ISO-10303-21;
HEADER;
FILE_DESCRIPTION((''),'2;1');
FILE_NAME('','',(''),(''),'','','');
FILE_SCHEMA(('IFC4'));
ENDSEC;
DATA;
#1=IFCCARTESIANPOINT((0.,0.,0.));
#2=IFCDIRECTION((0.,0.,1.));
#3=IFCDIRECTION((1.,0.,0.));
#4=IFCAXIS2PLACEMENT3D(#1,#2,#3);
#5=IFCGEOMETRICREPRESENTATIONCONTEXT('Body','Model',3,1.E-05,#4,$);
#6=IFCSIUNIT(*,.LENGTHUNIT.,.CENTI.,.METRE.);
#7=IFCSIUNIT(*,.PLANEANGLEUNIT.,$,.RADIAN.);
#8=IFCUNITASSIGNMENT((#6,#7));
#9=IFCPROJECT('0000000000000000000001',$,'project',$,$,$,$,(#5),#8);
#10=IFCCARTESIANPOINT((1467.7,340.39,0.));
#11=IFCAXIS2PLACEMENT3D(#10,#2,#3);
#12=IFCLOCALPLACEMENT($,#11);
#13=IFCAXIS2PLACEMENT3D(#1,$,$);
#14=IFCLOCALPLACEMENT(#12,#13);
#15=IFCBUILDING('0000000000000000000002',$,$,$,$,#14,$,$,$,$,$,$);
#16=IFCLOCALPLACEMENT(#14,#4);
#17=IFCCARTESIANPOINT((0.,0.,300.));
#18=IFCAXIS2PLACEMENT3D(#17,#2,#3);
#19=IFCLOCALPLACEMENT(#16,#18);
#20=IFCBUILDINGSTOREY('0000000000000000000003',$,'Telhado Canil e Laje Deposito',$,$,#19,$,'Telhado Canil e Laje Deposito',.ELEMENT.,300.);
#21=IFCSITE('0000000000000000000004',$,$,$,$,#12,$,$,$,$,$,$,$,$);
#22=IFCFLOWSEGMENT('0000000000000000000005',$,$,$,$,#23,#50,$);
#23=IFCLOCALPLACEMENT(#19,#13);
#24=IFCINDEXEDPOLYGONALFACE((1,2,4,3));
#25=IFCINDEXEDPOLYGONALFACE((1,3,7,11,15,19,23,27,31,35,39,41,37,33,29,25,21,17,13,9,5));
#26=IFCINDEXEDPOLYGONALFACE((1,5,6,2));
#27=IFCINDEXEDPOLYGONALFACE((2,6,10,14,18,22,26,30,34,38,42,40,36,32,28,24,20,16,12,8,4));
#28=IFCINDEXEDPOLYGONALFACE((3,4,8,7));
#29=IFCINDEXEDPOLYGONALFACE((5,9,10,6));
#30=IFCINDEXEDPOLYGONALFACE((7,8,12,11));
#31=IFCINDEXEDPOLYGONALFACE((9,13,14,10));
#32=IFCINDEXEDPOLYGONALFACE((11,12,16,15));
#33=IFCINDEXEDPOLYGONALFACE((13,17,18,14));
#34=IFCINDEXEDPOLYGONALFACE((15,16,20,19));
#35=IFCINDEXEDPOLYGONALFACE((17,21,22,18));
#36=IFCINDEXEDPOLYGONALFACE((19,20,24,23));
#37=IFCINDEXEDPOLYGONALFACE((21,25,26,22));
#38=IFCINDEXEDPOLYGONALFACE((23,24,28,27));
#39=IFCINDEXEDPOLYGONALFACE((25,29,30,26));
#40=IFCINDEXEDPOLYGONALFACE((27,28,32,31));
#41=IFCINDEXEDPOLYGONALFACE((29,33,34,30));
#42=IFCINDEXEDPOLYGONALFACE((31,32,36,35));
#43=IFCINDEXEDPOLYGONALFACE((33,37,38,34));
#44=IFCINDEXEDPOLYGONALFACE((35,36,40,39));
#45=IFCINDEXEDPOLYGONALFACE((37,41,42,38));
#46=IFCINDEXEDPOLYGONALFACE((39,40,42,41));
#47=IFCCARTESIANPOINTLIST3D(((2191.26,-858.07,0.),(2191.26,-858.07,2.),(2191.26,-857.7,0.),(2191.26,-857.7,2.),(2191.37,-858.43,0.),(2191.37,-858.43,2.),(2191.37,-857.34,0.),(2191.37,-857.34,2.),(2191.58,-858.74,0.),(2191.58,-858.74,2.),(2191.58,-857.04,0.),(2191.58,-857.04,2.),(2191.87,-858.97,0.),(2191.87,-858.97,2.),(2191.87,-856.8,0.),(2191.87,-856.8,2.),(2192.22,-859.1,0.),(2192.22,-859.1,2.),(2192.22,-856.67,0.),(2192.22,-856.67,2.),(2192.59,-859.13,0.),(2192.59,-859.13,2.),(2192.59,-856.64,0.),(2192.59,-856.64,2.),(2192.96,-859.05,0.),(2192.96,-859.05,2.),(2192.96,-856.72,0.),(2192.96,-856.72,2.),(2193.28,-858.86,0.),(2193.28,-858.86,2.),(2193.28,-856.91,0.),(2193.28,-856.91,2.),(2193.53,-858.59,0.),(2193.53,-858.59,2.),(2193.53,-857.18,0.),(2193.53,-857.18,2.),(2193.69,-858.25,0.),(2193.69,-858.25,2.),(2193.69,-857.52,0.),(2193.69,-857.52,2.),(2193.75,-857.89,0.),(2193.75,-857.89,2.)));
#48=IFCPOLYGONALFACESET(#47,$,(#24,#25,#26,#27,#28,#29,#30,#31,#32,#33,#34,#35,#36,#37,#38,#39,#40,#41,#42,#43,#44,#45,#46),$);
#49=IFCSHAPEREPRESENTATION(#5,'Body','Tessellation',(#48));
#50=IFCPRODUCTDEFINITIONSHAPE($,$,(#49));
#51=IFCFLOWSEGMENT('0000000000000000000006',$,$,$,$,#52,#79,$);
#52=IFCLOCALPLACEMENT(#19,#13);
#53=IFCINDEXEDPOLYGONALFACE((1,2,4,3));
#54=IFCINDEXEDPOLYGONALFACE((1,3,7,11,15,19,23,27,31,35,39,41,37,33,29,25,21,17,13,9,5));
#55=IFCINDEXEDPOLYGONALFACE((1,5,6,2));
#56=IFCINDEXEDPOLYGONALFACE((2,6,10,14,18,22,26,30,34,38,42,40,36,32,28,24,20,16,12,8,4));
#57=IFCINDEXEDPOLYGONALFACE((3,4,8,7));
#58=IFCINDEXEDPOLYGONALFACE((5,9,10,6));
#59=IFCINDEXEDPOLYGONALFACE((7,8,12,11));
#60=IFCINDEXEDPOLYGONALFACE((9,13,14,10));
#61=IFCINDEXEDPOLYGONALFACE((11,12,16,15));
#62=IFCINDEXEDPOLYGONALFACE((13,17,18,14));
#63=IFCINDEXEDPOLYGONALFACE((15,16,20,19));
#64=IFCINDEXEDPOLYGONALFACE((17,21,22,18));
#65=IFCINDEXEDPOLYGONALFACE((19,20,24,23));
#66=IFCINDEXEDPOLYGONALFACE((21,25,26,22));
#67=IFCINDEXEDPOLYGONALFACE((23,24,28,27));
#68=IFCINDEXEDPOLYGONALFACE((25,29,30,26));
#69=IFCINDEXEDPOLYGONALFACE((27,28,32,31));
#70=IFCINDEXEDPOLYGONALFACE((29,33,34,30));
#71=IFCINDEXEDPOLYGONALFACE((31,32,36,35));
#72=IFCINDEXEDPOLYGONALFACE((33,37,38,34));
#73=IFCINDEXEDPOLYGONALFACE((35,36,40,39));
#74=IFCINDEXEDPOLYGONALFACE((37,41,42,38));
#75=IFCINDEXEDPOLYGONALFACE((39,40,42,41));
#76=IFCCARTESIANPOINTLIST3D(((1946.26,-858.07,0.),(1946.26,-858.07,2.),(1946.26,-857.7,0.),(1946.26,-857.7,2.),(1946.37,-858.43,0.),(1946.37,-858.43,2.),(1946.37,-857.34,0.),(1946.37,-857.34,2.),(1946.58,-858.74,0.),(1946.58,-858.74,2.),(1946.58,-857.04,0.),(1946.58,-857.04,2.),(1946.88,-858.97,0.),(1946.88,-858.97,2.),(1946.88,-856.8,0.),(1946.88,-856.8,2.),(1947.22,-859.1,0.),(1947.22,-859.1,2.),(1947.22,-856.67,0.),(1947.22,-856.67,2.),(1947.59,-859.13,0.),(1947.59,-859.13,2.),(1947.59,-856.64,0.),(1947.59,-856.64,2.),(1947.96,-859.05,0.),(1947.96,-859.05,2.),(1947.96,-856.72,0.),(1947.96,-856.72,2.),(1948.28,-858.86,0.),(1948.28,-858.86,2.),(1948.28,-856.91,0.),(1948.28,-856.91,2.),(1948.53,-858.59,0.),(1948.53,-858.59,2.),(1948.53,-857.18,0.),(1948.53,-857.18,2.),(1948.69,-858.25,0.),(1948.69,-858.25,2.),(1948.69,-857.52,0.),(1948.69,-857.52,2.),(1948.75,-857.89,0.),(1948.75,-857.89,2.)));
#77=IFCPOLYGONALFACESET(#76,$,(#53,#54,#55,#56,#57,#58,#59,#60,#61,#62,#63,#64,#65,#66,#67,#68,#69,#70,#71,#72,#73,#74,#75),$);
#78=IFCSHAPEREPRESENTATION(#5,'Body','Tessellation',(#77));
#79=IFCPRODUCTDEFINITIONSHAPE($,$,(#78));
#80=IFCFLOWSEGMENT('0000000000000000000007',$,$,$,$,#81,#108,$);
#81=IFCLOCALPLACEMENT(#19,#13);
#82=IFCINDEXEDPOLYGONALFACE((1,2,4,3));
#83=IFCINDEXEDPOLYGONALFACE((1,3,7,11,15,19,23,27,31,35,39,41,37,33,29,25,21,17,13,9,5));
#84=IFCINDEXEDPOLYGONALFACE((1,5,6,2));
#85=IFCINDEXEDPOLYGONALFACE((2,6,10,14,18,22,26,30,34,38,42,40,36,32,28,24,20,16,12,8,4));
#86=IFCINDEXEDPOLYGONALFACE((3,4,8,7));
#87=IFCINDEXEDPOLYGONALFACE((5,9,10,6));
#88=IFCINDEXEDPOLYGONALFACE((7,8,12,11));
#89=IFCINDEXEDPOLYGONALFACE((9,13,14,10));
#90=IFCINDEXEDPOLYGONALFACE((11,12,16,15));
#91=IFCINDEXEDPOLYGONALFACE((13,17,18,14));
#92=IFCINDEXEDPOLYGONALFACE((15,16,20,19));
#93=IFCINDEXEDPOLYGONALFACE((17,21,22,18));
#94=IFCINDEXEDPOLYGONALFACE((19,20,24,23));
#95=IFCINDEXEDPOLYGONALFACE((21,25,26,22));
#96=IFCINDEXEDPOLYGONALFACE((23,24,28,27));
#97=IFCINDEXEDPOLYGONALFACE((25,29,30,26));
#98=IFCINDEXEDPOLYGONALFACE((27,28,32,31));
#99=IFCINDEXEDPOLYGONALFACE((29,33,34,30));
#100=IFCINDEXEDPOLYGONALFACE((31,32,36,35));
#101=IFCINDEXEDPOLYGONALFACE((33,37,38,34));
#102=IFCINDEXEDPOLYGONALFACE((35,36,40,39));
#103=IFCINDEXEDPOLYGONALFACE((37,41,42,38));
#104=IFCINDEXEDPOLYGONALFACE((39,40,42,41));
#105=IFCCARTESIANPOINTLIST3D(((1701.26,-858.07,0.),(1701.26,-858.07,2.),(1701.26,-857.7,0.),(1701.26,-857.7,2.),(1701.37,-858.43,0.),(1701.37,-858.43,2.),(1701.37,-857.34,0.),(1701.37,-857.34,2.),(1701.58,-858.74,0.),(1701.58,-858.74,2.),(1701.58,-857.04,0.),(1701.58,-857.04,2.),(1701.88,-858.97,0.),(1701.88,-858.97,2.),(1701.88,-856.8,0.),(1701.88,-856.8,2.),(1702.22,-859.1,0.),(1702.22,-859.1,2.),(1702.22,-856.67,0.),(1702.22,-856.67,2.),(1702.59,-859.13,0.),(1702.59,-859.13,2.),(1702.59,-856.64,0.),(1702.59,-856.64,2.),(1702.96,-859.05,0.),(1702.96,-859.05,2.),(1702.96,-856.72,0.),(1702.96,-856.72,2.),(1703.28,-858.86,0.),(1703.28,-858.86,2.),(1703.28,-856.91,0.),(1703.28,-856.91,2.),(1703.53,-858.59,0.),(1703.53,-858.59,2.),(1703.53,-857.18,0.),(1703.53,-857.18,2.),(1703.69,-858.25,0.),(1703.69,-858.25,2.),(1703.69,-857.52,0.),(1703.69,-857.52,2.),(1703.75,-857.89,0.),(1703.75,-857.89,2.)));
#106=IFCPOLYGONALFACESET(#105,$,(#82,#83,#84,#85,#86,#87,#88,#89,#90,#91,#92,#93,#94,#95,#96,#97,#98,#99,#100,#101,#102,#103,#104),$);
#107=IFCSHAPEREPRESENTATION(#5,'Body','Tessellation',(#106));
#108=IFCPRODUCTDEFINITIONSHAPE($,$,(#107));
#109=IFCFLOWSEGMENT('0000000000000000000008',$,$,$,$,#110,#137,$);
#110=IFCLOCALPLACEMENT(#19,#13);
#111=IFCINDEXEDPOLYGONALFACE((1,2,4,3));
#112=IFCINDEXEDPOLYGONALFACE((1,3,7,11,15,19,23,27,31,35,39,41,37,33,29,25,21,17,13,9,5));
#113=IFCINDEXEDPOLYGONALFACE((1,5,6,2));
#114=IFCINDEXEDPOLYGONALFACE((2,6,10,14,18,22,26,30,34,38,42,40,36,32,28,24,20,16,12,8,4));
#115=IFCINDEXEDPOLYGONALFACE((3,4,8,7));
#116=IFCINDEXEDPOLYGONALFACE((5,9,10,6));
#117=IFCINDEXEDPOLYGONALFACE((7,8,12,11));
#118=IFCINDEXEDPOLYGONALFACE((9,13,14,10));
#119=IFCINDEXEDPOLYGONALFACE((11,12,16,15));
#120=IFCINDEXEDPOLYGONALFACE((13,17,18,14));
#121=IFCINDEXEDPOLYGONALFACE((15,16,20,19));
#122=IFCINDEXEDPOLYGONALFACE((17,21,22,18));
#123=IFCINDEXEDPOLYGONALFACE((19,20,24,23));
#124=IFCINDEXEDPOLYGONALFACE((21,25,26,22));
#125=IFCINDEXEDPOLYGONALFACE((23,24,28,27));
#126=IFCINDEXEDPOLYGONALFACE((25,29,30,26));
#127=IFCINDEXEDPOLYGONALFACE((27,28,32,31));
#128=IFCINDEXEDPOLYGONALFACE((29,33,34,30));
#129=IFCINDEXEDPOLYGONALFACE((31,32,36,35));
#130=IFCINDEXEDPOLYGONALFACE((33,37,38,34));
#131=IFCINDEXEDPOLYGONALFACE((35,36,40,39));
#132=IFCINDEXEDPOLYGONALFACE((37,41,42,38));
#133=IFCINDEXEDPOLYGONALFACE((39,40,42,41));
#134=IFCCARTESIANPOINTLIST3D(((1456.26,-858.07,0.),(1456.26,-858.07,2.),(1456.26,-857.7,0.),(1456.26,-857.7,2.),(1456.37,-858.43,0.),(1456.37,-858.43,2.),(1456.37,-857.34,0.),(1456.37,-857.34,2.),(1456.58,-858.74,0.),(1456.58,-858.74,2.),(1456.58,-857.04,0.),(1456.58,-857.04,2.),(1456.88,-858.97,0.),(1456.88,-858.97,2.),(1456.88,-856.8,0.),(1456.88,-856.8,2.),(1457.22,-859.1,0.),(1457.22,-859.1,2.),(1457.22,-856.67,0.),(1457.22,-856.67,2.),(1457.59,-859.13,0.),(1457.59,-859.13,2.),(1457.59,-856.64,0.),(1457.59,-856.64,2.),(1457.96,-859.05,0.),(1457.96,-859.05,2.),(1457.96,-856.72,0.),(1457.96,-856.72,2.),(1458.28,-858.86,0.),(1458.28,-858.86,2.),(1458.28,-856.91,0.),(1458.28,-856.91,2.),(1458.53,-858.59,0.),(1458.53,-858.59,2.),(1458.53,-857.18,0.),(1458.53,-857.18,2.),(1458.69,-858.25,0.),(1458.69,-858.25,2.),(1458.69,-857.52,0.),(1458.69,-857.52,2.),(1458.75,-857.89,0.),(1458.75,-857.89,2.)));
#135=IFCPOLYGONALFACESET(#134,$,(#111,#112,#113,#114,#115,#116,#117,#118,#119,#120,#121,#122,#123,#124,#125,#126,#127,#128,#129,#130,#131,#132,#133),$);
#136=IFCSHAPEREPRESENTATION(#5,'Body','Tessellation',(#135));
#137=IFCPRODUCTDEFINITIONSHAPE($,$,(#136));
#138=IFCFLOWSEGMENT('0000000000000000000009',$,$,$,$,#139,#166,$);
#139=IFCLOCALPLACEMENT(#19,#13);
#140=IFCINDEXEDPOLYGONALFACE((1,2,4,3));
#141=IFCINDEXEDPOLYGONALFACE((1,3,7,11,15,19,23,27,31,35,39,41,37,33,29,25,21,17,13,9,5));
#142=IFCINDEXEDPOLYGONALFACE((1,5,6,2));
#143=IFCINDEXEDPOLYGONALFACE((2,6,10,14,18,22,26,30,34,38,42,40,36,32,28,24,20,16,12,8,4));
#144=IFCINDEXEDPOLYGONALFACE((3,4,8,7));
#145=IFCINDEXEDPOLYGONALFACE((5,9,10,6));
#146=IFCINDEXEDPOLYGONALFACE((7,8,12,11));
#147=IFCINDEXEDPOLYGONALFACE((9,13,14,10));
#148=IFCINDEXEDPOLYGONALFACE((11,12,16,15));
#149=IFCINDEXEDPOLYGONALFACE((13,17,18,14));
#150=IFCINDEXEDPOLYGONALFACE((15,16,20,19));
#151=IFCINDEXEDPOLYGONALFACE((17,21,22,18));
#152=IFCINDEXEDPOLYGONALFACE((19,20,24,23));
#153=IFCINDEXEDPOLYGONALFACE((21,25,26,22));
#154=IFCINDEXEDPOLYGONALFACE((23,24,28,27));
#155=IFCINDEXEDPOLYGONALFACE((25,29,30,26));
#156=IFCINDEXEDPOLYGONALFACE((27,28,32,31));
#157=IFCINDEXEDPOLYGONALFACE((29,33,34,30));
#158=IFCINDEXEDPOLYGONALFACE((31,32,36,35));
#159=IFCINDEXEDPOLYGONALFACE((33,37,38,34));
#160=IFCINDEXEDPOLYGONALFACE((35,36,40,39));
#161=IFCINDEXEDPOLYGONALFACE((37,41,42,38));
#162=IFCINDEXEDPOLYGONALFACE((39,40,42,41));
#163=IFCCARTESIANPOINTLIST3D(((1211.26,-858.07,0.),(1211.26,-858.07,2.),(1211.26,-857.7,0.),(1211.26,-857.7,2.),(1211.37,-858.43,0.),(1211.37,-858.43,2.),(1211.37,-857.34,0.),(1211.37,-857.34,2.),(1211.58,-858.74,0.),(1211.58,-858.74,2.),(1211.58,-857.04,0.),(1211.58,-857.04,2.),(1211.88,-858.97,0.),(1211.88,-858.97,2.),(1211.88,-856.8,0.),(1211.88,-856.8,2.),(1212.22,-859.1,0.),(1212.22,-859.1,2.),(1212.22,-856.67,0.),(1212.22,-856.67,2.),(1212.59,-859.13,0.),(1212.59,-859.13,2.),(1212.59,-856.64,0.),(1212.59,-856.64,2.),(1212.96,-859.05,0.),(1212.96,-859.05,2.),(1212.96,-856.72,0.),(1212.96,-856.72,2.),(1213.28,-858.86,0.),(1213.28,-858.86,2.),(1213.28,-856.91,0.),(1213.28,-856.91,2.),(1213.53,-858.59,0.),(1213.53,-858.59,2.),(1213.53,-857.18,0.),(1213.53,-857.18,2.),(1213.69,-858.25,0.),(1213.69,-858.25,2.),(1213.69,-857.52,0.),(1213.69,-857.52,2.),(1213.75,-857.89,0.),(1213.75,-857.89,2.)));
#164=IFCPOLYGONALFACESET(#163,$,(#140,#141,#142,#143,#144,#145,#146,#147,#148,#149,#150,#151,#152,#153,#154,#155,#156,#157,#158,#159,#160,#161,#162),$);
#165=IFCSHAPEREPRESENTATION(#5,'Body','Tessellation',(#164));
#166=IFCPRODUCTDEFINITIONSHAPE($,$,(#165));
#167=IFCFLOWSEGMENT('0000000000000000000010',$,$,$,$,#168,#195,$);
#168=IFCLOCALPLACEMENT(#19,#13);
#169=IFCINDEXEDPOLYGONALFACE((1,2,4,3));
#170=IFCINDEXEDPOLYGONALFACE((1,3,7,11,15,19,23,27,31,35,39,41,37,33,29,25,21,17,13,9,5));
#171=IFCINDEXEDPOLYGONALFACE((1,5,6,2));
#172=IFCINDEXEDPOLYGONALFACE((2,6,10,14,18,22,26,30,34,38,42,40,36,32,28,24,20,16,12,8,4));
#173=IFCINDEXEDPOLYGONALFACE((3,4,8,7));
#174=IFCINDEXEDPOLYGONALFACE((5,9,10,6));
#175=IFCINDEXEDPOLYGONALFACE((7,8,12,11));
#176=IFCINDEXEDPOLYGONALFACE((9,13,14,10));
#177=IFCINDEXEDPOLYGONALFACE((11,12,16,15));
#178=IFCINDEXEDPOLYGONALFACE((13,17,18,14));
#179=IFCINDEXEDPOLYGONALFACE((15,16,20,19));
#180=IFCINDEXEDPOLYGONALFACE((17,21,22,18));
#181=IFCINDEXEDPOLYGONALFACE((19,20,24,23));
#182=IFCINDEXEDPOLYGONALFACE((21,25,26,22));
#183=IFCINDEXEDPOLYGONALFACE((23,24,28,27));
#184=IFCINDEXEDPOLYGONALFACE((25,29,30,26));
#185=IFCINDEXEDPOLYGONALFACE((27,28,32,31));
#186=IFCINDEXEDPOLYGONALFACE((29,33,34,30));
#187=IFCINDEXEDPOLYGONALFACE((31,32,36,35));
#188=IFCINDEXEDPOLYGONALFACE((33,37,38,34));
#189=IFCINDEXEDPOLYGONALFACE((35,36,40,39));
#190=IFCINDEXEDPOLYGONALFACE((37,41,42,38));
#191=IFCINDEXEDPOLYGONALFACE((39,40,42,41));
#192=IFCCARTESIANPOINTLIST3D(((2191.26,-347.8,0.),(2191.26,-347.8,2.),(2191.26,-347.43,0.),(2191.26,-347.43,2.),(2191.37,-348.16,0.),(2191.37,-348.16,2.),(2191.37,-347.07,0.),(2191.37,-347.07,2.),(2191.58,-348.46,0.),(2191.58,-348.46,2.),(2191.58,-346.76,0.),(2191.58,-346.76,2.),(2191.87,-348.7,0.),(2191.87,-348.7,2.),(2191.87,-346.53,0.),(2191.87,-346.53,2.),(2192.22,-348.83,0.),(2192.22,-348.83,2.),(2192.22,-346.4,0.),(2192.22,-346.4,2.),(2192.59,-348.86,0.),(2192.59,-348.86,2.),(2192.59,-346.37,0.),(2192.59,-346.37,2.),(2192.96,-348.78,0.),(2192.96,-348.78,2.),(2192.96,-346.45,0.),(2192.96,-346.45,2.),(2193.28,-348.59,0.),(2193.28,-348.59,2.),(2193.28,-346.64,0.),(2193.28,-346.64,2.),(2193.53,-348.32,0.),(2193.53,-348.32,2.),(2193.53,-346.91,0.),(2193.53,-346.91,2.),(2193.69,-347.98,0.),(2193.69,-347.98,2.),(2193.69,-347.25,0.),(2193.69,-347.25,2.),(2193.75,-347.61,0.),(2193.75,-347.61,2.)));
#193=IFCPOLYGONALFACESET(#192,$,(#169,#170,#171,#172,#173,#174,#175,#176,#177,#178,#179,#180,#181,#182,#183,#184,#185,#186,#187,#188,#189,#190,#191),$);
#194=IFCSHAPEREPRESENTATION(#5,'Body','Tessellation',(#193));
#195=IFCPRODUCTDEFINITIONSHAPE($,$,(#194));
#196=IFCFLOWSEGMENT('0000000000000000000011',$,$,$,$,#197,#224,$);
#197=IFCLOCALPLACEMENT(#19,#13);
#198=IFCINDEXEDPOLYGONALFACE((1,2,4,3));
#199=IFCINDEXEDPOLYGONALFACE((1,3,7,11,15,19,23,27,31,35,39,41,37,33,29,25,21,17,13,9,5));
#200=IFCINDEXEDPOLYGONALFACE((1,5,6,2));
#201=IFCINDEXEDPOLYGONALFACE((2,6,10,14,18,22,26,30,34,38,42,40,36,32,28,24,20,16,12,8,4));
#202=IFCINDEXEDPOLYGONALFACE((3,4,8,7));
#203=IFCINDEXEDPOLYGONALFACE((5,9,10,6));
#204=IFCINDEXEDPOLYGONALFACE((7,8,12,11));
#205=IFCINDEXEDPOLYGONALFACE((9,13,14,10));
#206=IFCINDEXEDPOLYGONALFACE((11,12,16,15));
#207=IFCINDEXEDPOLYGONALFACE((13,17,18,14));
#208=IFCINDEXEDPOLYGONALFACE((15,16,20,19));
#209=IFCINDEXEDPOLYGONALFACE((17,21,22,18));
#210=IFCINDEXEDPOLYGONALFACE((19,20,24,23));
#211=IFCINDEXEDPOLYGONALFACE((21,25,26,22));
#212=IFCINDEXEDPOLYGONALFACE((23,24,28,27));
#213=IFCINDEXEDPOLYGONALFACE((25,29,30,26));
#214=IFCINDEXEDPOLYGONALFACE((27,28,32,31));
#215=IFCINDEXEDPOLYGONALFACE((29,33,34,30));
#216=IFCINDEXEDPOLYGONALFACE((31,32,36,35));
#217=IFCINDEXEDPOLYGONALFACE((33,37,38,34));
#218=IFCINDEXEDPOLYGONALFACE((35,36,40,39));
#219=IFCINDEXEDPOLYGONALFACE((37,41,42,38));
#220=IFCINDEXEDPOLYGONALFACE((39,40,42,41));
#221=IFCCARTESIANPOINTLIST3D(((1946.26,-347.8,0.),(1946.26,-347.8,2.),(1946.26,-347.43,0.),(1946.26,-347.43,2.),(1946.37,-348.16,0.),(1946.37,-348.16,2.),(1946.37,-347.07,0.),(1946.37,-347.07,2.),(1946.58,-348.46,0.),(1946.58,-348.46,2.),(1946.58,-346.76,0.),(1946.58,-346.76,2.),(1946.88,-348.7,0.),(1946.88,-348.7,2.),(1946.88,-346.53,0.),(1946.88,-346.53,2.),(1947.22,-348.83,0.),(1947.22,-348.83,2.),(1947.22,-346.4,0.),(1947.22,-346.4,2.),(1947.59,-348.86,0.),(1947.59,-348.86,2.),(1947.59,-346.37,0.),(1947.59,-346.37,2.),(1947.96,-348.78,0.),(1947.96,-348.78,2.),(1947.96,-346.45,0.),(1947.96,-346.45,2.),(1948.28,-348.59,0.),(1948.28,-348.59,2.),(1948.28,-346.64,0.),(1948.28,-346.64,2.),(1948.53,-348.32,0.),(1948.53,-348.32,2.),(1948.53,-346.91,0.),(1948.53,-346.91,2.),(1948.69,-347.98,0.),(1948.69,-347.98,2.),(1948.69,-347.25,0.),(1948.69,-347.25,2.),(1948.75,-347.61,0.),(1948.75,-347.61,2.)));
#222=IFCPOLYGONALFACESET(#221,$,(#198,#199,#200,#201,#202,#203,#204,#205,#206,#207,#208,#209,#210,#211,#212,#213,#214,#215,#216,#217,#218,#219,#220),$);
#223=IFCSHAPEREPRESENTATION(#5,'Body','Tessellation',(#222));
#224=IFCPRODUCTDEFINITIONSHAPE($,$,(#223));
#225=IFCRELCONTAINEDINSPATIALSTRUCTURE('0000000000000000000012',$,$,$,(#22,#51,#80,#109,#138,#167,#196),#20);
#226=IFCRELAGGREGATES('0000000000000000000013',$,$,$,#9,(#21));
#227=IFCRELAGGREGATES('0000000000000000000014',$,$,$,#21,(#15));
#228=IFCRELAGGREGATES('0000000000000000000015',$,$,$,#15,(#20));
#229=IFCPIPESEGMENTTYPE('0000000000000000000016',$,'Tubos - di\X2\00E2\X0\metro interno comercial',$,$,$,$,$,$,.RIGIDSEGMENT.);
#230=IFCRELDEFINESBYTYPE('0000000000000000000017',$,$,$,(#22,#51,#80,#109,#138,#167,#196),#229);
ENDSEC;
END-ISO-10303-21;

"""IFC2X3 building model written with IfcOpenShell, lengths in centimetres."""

from ifc_helpers import new_model, si_unit, frame, origin, origin_with_axes, origin_2d_with_axis, place, context, project, spatial, circle, extrude, type_object, element, save


model = new_model("IFC2X3")

# Units and contexts
model_context = context("Model", 3, precision=1e-05, world=origin_with_axes(), identifier="Body")
ifc_project = project(units=[si_unit("LENGTHUNIT", "METRE", prefix="CENTI"), si_unit("PLANEANGLEUNIT", "RADIAN")], contexts=[model_context])

# Site, building, storey
site_placement = place(None, frame((1467.7, 340.39, 0.0), z_axis=(0.0, 0.0, 1.0), x_axis=(1.0, 0.0, 0.0)))
site = spatial("IfcSite", under=ifc_project, at=site_placement)
building_placement = place(site_placement, origin())
building = spatial("IfcBuilding", under=site, at=building_placement)
placement = place(building_placement, origin_with_axes())
storey_placement = place(placement, frame((0.0, 0.0, 300.0), z_axis=(0.0, 0.0, 1.0), x_axis=(1.0, 0.0, 0.0)))
storey = spatial("IfcBuildingStorey", under=building, at=storey_placement, Name="Telhado Canil e Laje Deposito", LongName="Telhado Canil e Laje Deposito", CompositionType="ELEMENT", Elevation=300.0)

# Flow segments
pipe_segment_type = type_object("IfcPipeSegmentType", Name="Tubos - diâmetro interno comercial", PredefinedType="RIGIDSEGMENT")
for number, where, z_axis, x_axis in (
    (1, (2192.5, -857.89, 2.0), (0.0, 0.0, 1.0), (1.0, 0.0, 0.0)),
    (2, (1947.5, -857.89, 2.0), (0.0, 0.0, 1.0), (1.0, 0.0, 0.0)),
    (3, (1702.5, -857.89, 2.0), (0.0, 0.0, 1.0), (1.0, 0.0, 0.0)),
    (4, (1457.5, -857.89, 2.0), (0.0, 0.0, 1.0), (1.0, 0.0, 0.0)),
    (5, (1212.5, -857.89, 2.0), (0.0, 0.0, 1.0), (1.0, 0.0, 0.0)),
    (6, (2192.5, -347.61, 2.0), (0.0, 0.0, 1.0), (1.0, 0.0, 0.0)),
    (7, (1947.5, -347.61, 2.0), (0.0, 0.0, 1.0), (1.0, 0.0, 0.0)),
):
    element("IfcFlowSegment", number, at=place(storey_placement, frame(where, z_axis=z_axis, x_axis=x_axis)), inside=storey, type_object=pipe_segment_type, context=model_context, shape_type="SolidModel", body=[
        extrude(circle(Radius=1.25, at=origin_2d_with_axis()), frame((0.0, 0.0, 0.0), z_axis=(0.0, 0.0, -1.0), x_axis=(1.0, 0.0, 0.0)), (0.0, 0.0, 1.0), 2.0),
    ])

save(model, "model.ifc")
